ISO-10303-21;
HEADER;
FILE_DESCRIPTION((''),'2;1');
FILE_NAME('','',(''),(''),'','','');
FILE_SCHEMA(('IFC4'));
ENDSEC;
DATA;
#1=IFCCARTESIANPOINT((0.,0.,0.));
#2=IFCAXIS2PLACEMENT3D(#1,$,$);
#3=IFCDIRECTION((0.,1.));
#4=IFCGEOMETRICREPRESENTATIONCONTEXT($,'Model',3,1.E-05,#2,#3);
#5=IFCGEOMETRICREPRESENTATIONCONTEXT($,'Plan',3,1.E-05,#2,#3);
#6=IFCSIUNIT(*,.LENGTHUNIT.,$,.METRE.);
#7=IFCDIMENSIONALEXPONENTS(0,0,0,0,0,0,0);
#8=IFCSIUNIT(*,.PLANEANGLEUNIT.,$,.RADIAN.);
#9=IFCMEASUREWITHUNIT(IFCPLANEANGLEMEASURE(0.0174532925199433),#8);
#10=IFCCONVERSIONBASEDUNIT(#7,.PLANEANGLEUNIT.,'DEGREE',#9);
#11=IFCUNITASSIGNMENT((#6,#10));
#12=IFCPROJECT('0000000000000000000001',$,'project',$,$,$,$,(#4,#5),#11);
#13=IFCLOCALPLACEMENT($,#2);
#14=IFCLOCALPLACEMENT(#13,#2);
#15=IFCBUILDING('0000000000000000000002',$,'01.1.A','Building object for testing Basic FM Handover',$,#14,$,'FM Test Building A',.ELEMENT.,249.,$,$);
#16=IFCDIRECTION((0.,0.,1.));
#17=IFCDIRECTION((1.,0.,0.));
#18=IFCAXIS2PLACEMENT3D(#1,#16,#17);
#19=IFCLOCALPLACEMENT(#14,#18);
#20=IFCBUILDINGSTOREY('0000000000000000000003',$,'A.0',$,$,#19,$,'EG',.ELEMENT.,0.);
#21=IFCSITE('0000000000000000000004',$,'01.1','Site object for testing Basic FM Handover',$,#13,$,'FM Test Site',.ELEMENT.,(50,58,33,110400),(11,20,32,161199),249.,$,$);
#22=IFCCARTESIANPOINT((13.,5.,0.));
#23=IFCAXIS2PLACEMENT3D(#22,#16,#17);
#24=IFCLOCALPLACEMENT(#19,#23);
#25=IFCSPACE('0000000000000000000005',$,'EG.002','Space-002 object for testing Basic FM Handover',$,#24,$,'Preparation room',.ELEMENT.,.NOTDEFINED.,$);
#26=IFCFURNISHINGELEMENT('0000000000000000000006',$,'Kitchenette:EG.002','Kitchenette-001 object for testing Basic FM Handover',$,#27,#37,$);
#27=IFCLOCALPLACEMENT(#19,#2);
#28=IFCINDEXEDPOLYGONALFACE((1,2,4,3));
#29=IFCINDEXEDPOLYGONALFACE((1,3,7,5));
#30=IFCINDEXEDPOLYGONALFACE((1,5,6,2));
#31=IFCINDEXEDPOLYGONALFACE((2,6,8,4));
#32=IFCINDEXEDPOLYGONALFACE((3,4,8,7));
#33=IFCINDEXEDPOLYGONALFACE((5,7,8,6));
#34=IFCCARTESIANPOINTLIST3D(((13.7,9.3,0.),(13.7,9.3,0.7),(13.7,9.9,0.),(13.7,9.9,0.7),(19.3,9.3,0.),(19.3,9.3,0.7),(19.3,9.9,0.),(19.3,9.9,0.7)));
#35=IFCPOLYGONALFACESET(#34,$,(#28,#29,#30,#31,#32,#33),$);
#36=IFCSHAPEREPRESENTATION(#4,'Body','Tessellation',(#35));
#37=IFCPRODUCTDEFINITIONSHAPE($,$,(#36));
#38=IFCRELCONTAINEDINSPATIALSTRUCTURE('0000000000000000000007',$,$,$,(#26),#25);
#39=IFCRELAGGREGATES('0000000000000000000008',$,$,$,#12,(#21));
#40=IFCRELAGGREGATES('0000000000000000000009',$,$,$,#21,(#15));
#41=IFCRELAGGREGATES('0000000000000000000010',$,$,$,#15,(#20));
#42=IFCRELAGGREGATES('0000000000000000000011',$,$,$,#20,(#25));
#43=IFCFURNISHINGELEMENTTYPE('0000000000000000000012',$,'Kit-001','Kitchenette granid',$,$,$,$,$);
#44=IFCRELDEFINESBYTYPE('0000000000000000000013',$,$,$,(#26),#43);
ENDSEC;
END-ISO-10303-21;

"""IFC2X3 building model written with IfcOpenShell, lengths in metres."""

from ifc_helpers import new_model, entity, si_unit, converted_unit, direction, frame, frame_2d, origin, origin_with_axes, place, context, project, spatial, rectangle, extrude, type_object, element, save


model = new_model("IFC2X3")

# Units and contexts
model_context = context("Model", 3, precision=1e-05, world=origin(), true_north=direction((0.0, 1.0)))
plan_context = context("Plan", 3, precision=1e-05, world=origin(), true_north=direction((0.0, 1.0)))
ifc_project = project(units=[si_unit("LENGTHUNIT", "METRE"), converted_unit("PLANEANGLEUNIT", "DEGREE", entity("IfcPlaneAngleMeasure", 0.0174532925199433), si_unit("PLANEANGLEUNIT", "RADIAN"), dimensions=[0, 0, 0, 0, 0, 0, 0])], contexts=[model_context, plan_context])

# Site, building, storey
site_placement = place(None, origin())
site = spatial("IfcSite", under=ifc_project, at=site_placement, Name="01.1", Description="Site object for testing Basic FM Handover", LongName="FM Test Site", CompositionType="ELEMENT", RefLatitude=(50, 58, 33, 110400), RefLongitude=(11, 20, 32, 161199), RefElevation=249.0)
building_placement = place(site_placement, origin())
building = spatial("IfcBuilding", under=site, at=building_placement, Name="01.1.A", Description="Building object for testing Basic FM Handover", LongName="FM Test Building A", CompositionType="ELEMENT", ElevationOfRefHeight=249.0)
storey_placement = place(building_placement, origin_with_axes())
storey = spatial("IfcBuildingStorey", under=building, at=storey_placement, Name="A.0", LongName="EG", CompositionType="ELEMENT", Elevation=0.0)

# Shared definitions
space_1_placement = place(storey_placement, frame((13.0, 5.0, 0.0), z_axis=(0.0, 0.0, 1.0), x_axis=(1.0, 0.0, 0.0)))
space_1 = spatial("IfcSpace", under=storey, at=space_1_placement, Name="EG.002", Description="Space-002 object for testing Basic FM Handover", LongName="Preparation room", CompositionType="ELEMENT", InteriorOrExteriorSpace="NOTDEFINED")

# Furnishing element
furnishing_element_type_1 = type_object("IfcFurnishingElementType", Name="Kit-001", Description="Kitchenette granid")
furnishing_placement = place(storey_placement, frame((13.7, 9.3, 0.0), z_axis=(0.0, 0.0, 1.0), x_axis=(1.0, 0.0, 0.0)))
element("IfcFurnishingElement", 1, at=furnishing_placement, inside=space_1, type_object=furnishing_element_type_1, Name="Kitchenette:EG.002", Description="Kitchenette-001 object for testing Basic FM Handover", context=model_context, shape_type="SweptSolid", body=[
    extrude(rectangle(XDim=5.6, YDim=0.6, at=frame_2d((2.8, 0.3))), origin(), (0.0, 0.0, 1.0), 0.7),
])

save(model, "model.ifc")
